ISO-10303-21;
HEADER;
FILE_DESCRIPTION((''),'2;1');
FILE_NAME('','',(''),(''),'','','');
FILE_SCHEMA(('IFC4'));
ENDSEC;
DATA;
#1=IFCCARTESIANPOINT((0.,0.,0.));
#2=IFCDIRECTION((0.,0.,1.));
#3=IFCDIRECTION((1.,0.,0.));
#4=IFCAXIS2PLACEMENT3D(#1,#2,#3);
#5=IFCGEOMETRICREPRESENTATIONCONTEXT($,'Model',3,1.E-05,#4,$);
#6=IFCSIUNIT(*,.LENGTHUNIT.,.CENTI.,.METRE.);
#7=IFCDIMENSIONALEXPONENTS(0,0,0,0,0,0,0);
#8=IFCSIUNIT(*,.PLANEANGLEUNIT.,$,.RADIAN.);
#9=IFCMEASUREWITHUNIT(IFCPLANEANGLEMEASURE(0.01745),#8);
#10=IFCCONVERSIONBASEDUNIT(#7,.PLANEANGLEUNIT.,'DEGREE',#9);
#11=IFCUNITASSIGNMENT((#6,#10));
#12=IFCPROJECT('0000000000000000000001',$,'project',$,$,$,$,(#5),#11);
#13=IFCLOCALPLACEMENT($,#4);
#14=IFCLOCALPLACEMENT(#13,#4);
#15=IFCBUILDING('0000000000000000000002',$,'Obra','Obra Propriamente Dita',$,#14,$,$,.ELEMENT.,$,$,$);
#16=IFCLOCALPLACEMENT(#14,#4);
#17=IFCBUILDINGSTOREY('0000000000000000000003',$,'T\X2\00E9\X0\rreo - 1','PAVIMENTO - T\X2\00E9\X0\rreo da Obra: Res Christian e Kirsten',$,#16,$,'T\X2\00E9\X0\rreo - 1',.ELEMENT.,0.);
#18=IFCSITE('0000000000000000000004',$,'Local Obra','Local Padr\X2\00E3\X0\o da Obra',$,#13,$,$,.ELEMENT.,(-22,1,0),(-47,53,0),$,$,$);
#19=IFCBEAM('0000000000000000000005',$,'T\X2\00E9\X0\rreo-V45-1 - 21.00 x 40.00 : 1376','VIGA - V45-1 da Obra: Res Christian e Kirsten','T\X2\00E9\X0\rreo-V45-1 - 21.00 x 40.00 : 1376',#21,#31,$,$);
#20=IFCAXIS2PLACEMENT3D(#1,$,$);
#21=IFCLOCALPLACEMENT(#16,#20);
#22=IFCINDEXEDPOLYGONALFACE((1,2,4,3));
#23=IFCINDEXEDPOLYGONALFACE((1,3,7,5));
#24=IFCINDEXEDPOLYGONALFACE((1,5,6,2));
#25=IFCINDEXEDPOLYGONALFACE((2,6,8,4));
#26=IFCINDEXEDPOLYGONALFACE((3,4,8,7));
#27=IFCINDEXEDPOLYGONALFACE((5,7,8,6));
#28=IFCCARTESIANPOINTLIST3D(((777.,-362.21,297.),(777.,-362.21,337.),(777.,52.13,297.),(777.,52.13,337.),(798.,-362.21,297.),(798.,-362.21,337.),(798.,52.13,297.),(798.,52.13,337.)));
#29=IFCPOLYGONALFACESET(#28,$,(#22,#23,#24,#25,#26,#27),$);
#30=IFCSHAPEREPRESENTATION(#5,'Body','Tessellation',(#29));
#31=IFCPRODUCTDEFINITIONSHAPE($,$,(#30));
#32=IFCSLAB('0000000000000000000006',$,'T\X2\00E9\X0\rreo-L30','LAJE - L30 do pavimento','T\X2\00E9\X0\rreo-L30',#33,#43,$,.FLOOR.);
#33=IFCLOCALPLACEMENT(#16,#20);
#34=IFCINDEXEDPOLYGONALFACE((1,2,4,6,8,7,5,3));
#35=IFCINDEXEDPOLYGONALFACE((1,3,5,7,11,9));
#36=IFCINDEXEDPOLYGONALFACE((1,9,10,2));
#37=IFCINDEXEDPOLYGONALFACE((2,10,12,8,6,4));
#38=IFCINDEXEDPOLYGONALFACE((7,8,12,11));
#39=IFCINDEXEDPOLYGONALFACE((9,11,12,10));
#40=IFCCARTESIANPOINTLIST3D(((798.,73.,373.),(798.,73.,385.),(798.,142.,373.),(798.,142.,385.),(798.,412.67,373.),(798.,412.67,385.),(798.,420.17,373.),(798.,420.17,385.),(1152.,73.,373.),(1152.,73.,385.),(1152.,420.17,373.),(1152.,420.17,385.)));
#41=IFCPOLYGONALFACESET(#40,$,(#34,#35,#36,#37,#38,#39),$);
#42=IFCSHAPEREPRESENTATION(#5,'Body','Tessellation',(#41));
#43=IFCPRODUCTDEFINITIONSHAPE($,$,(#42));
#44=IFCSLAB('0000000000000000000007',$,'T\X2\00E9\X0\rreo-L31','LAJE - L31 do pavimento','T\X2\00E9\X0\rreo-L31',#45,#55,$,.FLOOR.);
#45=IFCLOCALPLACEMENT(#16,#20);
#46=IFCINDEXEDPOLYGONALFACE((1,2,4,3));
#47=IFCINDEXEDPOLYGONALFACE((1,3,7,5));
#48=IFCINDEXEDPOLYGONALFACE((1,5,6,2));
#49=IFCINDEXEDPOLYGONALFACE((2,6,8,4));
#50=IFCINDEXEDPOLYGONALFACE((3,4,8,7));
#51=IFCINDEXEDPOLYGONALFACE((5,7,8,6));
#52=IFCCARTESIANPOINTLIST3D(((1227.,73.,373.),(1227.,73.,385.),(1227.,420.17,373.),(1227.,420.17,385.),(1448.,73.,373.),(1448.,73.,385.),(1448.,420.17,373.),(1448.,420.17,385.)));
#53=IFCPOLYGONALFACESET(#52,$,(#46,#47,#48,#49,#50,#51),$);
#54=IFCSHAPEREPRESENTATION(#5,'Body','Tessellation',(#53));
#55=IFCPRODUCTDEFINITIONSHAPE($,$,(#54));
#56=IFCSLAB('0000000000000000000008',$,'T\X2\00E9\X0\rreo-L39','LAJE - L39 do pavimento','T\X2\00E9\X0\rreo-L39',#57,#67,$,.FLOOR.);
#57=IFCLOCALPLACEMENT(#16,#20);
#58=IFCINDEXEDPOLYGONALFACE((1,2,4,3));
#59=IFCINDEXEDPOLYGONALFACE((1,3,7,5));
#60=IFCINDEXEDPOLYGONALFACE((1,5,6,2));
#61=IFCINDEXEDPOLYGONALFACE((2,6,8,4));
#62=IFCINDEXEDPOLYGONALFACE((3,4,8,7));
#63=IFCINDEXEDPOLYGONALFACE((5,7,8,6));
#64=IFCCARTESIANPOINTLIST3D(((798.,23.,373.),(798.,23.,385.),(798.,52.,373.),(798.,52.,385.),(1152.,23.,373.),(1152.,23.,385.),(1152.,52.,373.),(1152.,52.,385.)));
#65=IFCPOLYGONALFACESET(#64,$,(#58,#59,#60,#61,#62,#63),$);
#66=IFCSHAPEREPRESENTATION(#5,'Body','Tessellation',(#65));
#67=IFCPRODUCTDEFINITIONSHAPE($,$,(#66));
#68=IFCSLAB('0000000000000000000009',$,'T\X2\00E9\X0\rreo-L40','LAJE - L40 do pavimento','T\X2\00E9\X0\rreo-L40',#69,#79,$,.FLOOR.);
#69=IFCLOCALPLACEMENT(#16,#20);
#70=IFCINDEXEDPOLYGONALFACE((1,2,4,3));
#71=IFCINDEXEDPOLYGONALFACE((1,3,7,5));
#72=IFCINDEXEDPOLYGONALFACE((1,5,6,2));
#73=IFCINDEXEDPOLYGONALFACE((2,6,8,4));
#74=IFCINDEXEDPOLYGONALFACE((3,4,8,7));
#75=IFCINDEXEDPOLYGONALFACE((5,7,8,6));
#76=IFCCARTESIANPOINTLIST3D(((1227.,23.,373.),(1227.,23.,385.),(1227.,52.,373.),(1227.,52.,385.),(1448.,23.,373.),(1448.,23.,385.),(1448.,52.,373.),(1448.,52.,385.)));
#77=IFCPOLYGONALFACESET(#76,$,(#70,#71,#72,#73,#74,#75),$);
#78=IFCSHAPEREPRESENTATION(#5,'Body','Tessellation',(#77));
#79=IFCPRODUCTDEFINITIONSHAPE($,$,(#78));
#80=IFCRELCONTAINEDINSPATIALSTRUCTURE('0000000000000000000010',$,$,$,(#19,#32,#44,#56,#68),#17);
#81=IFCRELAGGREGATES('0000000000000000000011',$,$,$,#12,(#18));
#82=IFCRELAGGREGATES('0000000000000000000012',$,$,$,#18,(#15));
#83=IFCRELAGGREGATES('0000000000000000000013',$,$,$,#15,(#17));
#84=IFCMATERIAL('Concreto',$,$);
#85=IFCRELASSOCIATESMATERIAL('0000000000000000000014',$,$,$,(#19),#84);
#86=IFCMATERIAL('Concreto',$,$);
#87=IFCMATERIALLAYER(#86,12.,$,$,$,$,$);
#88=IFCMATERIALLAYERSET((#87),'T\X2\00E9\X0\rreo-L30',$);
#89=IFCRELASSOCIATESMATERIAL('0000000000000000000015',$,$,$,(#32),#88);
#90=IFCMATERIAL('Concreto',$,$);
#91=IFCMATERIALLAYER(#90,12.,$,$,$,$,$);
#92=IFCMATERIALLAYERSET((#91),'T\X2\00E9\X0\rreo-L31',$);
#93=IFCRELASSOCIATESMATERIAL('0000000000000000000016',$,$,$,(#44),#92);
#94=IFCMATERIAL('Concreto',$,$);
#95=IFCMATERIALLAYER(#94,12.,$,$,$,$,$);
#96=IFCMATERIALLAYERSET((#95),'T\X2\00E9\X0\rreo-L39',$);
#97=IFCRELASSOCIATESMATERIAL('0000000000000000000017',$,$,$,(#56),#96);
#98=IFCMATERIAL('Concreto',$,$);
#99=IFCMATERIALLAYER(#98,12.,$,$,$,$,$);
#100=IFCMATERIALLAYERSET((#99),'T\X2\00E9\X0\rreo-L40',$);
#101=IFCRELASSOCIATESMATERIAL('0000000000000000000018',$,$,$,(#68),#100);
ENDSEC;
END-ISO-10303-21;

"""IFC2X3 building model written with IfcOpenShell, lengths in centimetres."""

from ifc_helpers import new_model, entity, si_unit, converted_unit, frame, origin_with_axes, place, context, project, spatial, polyline, outline, extrude, material, layer, layer_set, layer_usage, element, save


model = new_model("IFC2X3")

# Units and contexts
model_context = context("Model", 3, precision=1e-05, world=origin_with_axes())
ifc_project = project(units=[si_unit("LENGTHUNIT", "METRE", prefix="CENTI"), converted_unit("PLANEANGLEUNIT", "DEGREE", entity("IfcPlaneAngleMeasure", 0.01745), si_unit("PLANEANGLEUNIT", "RADIAN"), dimensions=[0, 0, 0, 0, 0, 0, 0])], contexts=[model_context])

# Site, building, storey
site_placement = place(None, origin_with_axes())
site = spatial("IfcSite", under=ifc_project, at=site_placement, Name="Local Obra", Description="Local Padrão da Obra", CompositionType="ELEMENT", RefLatitude=(-22, 1, 0), RefLongitude=(-47, 53, 0))
building_placement = place(site_placement, origin_with_axes())
building = spatial("IfcBuilding", under=site, at=building_placement, Name="Obra", Description="Obra Propriamente Dita", CompositionType="ELEMENT")
storey_placement = place(building_placement, origin_with_axes())
storey = spatial("IfcBuildingStorey", under=building, at=storey_placement, Name="Térreo - 1", Description="PAVIMENTO - Térreo da Obra: Res Christian e Kirsten", LongName="Térreo - 1", CompositionType="ELEMENT", Elevation=0.0)

# Beam
ifc_material_1 = material(Name="Concreto")
beam_1_placement = place(storey_placement, frame((777.0, -362.21, 337.0), z_axis=(0.0, 1.0, 0.0), x_axis=(1.0, 0.0, 0.0)))
element("IfcBeam", 1, at=beam_1_placement, inside=storey, material=ifc_material_1, Name="Térreo-V45-1 - 21.00 x 40.00 : 1376", Description="VIGA - V45-1 da Obra: Res Christian e Kirsten", ObjectType="Térreo-V45-1 - 21.00 x 40.00 : 1376", context=model_context, shape_type="SweptSolid", body=[
    extrude(outline(polyline([(0.0, 0.0), (21.0, 0.0), (21.0, 40.0), (0.0, 40.0), (0.0, 0.0)])), origin_with_axes(), (0.0, 0.0, 1.0), 414.34),
])

# Slabs
ifc_material_2 = material(Name="Concreto")
ifc_layer_1 = layer(ifc_material_2, 12.0)
ifc_layer_set_1 = layer_set([ifc_layer_1], Name="Térreo-L30")
ifc_layer_usage_1 = layer_usage(ifc_layer_set_1, "AXIS3", "POSITIVE", 0.0)
slab_1_placement = place(storey_placement, frame((1152.0, 73.0, 373.0), z_axis=(0.0, 0.0, 1.0), x_axis=(1.0, 0.0, 0.0)))
element("IfcSlab", 2, at=slab_1_placement, inside=storey, material=ifc_layer_usage_1, Name="Térreo-L30", Description="LAJE - L30 do pavimento", ObjectType="Térreo-L30", PredefinedType="FLOOR", context=model_context, shape_type="SweptSolid", body=[
    extrude(outline(polyline([(0.0, 347.17), (-354.0, 347.17), (-354.0, 339.67), (-354.0, 69.0), (-354.0, 0.0), (0.0, 0.0), (0.0, 347.17)])), origin_with_axes(), (0.0, 0.0, 1.0), 12.0),
])
ifc_material_3 = material(Name="Concreto")
ifc_layer_2 = layer(ifc_material_3, 12.0)
ifc_layer_set_2 = layer_set([ifc_layer_2], Name="Térreo-L31")
ifc_layer_usage_2 = layer_usage(ifc_layer_set_2, "AXIS3", "POSITIVE", 0.0)
slab_2_placement = place(storey_placement, frame((1448.0, 73.0, 373.0), z_axis=(0.0, 0.0, 1.0), x_axis=(1.0, 0.0, 0.0)))
element("IfcSlab", 3, at=slab_2_placement, inside=storey, material=ifc_layer_usage_2, Name="Térreo-L31", Description="LAJE - L31 do pavimento", ObjectType="Térreo-L31", PredefinedType="FLOOR", context=model_context, shape_type="SweptSolid", body=[
    extrude(outline(polyline([(0.0, 347.17), (-221.0, 347.17), (-221.0, 0.0), (0.0, 0.0), (0.0, 347.17)])), origin_with_axes(), (0.0, 0.0, 1.0), 12.0),
])
ifc_material_4 = material(Name="Concreto")
ifc_layer_3 = layer(ifc_material_4, 12.0)
ifc_layer_set_3 = layer_set([ifc_layer_3], Name="Térreo-L39")
ifc_layer_usage_3 = layer_usage(ifc_layer_set_3, "AXIS3", "POSITIVE", 0.0)
slab_3_placement = place(storey_placement, frame((1152.0, 23.0, 373.0), z_axis=(0.0, 0.0, 1.0), x_axis=(1.0, 0.0, 0.0)))
element("IfcSlab", 4, at=slab_3_placement, inside=storey, material=ifc_layer_usage_3, Name="Térreo-L39", Description="LAJE - L39 do pavimento", ObjectType="Térreo-L39", PredefinedType="FLOOR", context=model_context, shape_type="SweptSolid", body=[
    extrude(outline(polyline([(0.0, 29.0), (-354.0, 29.0), (-354.0, 0.0), (0.0, 0.0), (0.0, 29.0)])), origin_with_axes(), (0.0, 0.0, 1.0), 12.0),
])
ifc_material_5 = material(Name="Concreto")
ifc_layer_4 = layer(ifc_material_5, 12.0)
ifc_layer_set_4 = layer_set([ifc_layer_4], Name="Térreo-L40")
ifc_layer_usage_4 = layer_usage(ifc_layer_set_4, "AXIS3", "POSITIVE", 0.0)
slab_4_placement = place(storey_placement, frame((1448.0, 23.0, 373.0), z_axis=(0.0, 0.0, 1.0), x_axis=(1.0, 0.0, 0.0)))
element("IfcSlab", 5, at=slab_4_placement, inside=storey, material=ifc_layer_usage_4, Name="Térreo-L40", Description="LAJE - L40 do pavimento", ObjectType="Térreo-L40", PredefinedType="FLOOR", context=model_context, shape_type="SweptSolid", body=[
    extrude(outline(polyline([(0.0, 29.0), (-221.0, 29.0), (-221.0, 0.0), (0.0, 0.0), (0.0, 29.0)])), origin_with_axes(), (0.0, 0.0, 1.0), 12.0),
])

save(model, "model.ifc")
